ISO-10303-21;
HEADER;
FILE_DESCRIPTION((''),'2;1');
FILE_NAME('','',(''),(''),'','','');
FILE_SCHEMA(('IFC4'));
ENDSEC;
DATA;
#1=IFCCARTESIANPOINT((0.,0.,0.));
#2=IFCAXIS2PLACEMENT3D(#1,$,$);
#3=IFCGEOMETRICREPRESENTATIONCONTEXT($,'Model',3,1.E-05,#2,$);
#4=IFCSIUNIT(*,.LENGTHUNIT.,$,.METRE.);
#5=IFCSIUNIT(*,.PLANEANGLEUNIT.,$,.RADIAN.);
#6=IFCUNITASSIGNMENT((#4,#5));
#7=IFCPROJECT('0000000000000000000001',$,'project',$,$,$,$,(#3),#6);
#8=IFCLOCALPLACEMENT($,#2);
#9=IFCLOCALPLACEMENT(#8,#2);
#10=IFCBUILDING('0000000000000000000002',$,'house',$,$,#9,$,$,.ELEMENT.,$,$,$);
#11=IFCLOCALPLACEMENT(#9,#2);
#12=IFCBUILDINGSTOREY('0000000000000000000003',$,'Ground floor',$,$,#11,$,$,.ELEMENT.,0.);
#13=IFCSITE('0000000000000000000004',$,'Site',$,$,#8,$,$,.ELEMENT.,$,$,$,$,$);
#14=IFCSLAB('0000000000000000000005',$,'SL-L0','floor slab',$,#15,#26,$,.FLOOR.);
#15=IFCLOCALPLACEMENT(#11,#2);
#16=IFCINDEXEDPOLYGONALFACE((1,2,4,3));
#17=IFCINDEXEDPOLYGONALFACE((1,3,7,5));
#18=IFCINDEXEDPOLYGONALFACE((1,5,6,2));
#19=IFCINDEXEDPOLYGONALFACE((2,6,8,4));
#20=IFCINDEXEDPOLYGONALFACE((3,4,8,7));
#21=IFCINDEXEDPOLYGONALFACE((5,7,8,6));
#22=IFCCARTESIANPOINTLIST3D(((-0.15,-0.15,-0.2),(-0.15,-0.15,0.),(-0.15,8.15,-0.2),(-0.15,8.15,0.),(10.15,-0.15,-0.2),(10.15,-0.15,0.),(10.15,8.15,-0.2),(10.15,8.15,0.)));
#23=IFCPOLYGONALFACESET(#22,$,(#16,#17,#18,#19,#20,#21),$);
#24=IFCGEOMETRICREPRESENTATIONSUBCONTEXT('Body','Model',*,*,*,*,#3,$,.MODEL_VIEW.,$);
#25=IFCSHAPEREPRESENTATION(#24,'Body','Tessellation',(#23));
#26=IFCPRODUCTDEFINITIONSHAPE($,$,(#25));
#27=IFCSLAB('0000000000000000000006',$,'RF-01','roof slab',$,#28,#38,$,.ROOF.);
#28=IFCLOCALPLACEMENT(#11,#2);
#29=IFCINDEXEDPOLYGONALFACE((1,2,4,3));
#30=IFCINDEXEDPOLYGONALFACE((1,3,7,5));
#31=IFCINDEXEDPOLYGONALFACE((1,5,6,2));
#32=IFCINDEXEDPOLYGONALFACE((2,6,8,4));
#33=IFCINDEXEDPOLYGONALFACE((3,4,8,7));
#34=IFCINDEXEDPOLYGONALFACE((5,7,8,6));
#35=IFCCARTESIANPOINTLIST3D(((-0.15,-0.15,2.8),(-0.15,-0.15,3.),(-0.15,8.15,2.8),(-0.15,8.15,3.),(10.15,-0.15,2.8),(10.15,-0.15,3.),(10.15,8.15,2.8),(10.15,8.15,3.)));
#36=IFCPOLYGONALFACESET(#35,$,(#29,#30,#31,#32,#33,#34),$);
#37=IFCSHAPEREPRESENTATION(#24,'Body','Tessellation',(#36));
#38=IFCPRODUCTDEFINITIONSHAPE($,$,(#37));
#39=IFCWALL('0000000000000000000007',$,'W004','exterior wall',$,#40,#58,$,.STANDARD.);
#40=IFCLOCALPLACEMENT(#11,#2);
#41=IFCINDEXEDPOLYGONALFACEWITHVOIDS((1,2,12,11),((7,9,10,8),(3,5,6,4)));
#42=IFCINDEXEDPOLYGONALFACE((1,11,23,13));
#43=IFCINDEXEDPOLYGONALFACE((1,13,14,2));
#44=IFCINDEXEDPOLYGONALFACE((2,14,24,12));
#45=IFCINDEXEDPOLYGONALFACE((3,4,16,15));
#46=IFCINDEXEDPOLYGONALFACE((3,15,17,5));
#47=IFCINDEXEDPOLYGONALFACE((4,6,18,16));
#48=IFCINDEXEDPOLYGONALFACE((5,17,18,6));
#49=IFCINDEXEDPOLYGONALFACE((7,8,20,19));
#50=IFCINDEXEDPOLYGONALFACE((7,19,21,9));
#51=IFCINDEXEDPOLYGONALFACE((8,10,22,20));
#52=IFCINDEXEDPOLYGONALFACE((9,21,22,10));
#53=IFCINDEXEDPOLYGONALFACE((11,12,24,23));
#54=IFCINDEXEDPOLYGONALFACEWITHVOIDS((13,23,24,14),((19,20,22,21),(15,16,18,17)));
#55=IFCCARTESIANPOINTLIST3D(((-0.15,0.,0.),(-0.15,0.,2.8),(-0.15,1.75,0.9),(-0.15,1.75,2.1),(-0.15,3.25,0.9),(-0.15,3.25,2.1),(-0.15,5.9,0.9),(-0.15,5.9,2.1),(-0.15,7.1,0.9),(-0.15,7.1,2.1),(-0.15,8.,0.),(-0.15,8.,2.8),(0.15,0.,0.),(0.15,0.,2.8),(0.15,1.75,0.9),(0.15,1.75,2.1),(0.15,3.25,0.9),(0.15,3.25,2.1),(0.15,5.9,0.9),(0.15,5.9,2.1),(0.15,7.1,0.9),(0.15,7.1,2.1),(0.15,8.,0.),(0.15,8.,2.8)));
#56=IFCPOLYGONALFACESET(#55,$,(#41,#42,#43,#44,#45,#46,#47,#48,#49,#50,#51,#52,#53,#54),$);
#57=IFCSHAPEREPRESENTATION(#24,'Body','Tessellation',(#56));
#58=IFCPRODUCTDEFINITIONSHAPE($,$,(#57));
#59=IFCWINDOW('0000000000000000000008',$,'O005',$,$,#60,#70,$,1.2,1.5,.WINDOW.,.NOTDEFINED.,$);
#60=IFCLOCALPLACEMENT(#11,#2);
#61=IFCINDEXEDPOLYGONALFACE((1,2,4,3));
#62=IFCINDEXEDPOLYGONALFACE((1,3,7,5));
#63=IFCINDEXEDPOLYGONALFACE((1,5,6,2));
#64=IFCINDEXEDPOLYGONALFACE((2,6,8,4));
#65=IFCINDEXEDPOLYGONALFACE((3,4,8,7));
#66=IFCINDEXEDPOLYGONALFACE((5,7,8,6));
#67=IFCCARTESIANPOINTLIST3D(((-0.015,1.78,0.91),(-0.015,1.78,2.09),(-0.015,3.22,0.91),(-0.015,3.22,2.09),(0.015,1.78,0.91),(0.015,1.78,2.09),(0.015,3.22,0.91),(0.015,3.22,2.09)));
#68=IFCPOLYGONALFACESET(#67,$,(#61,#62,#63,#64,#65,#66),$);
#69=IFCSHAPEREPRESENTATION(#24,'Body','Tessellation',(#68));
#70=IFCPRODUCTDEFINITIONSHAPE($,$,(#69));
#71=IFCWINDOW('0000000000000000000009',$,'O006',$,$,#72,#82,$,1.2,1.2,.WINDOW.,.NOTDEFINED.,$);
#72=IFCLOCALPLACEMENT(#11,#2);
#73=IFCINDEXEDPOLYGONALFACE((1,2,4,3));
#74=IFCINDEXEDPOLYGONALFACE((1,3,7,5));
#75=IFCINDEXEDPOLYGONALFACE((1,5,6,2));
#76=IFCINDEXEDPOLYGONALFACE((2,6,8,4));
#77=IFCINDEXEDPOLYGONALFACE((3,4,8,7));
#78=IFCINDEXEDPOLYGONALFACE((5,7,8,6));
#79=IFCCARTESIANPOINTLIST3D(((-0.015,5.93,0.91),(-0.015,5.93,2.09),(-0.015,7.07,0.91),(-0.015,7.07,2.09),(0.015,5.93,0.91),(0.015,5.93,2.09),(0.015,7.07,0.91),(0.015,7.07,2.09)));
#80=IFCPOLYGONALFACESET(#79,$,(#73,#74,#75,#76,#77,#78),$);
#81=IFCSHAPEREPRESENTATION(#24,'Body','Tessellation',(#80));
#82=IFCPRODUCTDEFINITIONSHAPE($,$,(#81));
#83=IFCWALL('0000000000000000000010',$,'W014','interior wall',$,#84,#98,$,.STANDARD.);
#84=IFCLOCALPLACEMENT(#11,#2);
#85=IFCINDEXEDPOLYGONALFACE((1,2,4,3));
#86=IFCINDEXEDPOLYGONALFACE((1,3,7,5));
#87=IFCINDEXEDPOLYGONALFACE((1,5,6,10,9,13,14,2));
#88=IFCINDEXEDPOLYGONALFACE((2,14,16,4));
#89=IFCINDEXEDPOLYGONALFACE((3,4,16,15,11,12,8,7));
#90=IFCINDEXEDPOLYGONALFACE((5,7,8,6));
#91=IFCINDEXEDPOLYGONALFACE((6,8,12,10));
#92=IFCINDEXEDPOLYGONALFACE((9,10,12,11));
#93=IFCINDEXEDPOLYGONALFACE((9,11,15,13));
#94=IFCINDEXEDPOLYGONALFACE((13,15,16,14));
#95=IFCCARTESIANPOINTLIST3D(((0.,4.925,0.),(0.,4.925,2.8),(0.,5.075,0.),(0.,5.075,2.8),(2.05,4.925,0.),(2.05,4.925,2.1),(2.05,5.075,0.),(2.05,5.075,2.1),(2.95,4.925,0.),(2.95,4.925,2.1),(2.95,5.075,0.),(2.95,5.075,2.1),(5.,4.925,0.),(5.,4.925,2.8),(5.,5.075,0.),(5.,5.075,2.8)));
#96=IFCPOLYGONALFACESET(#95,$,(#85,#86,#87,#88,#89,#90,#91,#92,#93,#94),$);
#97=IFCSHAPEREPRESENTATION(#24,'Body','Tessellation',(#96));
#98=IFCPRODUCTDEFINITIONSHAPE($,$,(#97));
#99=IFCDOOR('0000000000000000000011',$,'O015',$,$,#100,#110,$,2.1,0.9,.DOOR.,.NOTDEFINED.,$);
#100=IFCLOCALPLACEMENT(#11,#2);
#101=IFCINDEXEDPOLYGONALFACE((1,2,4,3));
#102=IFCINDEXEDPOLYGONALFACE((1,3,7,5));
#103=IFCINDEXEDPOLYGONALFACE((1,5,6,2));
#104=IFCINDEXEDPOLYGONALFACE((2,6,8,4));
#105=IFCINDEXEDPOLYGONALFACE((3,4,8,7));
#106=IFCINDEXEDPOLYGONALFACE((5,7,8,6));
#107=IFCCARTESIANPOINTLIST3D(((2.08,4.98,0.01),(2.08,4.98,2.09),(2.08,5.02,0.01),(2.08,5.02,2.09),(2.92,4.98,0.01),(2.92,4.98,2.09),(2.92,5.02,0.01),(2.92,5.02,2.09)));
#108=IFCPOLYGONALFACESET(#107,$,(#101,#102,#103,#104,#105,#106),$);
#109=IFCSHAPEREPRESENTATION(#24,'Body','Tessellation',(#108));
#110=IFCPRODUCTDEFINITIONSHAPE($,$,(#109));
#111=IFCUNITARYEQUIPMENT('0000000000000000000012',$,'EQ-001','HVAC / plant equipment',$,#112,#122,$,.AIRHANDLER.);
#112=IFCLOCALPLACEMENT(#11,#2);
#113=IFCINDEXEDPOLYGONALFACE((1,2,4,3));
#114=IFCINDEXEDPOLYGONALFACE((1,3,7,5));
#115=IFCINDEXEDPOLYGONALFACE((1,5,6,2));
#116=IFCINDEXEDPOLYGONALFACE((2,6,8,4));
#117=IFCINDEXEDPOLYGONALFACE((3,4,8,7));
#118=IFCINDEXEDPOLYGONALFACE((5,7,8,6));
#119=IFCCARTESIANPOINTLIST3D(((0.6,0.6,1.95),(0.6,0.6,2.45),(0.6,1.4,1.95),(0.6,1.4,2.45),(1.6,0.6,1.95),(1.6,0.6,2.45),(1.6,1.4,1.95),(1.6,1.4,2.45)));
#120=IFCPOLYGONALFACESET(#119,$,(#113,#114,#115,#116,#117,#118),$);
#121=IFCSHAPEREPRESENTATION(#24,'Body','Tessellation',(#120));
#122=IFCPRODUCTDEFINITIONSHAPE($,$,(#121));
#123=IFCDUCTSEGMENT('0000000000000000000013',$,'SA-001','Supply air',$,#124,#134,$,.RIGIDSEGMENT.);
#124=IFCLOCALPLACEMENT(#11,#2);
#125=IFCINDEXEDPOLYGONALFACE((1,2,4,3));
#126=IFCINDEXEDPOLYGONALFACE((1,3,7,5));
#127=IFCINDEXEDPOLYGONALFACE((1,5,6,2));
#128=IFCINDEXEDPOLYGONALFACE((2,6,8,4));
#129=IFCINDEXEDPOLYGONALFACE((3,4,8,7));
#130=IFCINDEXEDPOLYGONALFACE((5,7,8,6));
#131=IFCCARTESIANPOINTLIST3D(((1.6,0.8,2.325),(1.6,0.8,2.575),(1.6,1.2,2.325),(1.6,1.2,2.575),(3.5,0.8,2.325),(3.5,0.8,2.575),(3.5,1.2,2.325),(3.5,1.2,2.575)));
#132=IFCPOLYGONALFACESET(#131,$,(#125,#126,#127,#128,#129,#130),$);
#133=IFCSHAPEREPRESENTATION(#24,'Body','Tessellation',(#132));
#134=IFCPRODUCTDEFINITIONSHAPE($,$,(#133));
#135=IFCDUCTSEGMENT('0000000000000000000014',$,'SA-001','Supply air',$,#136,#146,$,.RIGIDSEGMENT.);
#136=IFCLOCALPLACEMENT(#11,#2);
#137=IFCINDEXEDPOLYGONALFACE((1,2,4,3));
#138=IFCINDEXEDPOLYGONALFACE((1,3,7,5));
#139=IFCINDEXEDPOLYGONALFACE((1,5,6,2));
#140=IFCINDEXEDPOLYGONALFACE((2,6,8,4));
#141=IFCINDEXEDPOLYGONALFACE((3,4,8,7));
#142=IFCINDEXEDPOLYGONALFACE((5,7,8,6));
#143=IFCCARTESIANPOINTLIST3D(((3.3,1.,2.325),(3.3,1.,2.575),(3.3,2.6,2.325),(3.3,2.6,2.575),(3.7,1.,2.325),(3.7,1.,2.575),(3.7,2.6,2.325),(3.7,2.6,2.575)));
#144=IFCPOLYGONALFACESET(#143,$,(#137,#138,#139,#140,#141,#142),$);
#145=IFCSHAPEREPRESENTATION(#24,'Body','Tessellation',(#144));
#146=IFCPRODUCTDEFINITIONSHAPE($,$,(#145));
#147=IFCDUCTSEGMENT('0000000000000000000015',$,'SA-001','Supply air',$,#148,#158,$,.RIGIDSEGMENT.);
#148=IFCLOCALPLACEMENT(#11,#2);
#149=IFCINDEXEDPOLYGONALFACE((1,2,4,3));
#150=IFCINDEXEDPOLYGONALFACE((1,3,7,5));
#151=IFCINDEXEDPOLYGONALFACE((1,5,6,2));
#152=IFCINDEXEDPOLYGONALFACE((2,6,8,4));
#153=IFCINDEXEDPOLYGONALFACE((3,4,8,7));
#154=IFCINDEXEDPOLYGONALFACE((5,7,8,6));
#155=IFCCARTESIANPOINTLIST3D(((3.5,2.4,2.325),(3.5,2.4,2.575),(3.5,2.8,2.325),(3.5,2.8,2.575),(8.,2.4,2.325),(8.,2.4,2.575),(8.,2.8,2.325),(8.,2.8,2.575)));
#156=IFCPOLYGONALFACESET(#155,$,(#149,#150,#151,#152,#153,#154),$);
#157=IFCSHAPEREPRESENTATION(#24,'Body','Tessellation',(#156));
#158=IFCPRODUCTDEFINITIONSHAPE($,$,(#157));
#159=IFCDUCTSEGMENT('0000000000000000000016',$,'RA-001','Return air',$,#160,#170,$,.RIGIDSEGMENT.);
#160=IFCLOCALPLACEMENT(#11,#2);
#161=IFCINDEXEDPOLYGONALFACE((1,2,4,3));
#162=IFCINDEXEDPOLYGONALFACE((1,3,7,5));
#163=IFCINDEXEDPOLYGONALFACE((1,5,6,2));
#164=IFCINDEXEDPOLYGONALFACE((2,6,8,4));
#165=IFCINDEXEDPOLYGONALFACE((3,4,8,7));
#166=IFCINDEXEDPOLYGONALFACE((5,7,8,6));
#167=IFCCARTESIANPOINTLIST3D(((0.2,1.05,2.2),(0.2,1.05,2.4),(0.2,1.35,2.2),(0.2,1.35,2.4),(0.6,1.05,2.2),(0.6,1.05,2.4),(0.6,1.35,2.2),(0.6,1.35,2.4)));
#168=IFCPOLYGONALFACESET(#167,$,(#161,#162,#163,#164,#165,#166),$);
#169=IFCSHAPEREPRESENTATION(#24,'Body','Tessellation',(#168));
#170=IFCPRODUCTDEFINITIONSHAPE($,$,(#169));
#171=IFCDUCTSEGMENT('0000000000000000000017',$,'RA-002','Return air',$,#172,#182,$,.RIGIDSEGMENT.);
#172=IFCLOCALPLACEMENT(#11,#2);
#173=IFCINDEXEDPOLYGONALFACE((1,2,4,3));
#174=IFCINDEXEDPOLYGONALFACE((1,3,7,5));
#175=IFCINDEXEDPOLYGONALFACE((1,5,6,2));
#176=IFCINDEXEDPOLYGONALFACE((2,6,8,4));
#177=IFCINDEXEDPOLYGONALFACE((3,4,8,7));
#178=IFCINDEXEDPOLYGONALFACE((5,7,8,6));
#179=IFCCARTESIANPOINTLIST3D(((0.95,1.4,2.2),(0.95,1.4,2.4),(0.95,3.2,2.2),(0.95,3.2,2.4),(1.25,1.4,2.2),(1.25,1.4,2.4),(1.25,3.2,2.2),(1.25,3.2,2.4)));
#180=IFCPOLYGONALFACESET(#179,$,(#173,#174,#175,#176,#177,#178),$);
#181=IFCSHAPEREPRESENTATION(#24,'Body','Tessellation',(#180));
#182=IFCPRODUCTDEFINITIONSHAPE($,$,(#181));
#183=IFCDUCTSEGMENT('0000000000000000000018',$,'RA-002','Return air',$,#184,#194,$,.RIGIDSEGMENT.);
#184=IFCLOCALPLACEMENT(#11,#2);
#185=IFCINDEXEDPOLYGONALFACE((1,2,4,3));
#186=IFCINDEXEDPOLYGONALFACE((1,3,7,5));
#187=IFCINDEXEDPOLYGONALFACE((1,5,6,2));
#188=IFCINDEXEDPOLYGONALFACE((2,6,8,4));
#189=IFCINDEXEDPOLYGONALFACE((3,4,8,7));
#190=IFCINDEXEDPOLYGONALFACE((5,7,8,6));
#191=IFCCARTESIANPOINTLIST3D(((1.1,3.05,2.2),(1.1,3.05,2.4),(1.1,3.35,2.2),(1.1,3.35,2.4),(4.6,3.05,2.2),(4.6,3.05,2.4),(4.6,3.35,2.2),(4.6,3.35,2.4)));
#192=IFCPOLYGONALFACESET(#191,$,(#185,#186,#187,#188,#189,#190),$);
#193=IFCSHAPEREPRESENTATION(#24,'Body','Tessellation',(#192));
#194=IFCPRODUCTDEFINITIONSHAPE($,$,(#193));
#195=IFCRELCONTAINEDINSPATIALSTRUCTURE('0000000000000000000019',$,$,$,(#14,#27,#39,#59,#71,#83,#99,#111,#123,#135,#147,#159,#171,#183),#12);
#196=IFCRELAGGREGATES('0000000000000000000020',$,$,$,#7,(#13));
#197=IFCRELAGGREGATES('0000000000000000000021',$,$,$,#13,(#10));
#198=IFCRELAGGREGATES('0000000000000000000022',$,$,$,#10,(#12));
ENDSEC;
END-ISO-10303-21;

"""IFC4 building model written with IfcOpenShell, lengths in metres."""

from ifc_helpers import new_model, si_unit, frame, origin, origin_2d, place, context, subcontext, project, spatial, polyline, rectangle, outline, extrude, element, fill, save


model = new_model("IFC4")

# Units and contexts
model_context = context("Model", 3, precision=1e-05, world=origin())
body_context = subcontext(model_context, "Body", "Model", "MODEL_VIEW")
ifc_project = project(units=[si_unit("LENGTHUNIT", "METRE"), si_unit("PLANEANGLEUNIT", "RADIAN")], contexts=[model_context])

# Site, building, storey
site_placement = place(None, origin())
site = spatial("IfcSite", under=ifc_project, at=site_placement, Name="Site", CompositionType="ELEMENT")
building_placement = place(site_placement, origin())
building = spatial("IfcBuilding", under=site, at=building_placement, Name="house", CompositionType="ELEMENT")
storey_placement = place(building_placement, origin())
storey = spatial("IfcBuildingStorey", under=building, at=storey_placement, Name="Ground floor", CompositionType="ELEMENT", Elevation=0.0)

# Slabs
slab_1_placement = place(storey_placement, frame((0.0, 0.0, -0.2)))
element("IfcSlab", 1, at=slab_1_placement, inside=storey, Name="SL-L0", Description="floor slab", PredefinedType="FLOOR", context=body_context, shape_type="SweptSolid", body=[
    extrude(outline(polyline([(-0.15, 8.15), (10.15, 8.15), (10.15, -0.15), (-0.15, -0.15), (-0.15, 8.15)])), origin(), (0.0, 0.0, 1.0), 0.2),
])
slab_2_placement = place(storey_placement, frame((0.0, 0.0, 2.8)))
element("IfcSlab", 2, at=slab_2_placement, inside=storey, Name="RF-01", Description="roof slab", PredefinedType="ROOF", context=body_context, shape_type="SweptSolid", body=[
    extrude(outline(polyline([(-0.15, 8.15), (10.15, 8.15), (10.15, -0.15), (-0.15, -0.15), (-0.15, 8.15)])), origin(), (0.0, 0.0, 1.0), 0.2),
])

# Wall, openings, windows
wall_1_placement = place(storey_placement, frame((0.0, 4.0, 0.0), z_axis=(0.0, 0.0, 1.0), x_axis=(0.0, 1.0, 0.0)))
wall_1 = element("IfcWall", 3, at=wall_1_placement, inside=storey, Name="W004", Description="exterior wall", PredefinedType="STANDARD", context=body_context, shape_type="SweptSolid", body=[
    extrude(rectangle(XDim=8.0, YDim=0.3, at=origin_2d()), origin(), (0.0, 0.0, 1.0), 2.8),
])
opening_1_placement = place(wall_1_placement, frame((-1.5, 0.0, 0.9)))
opening_1 = element("IfcOpeningElement", 4, at=opening_1_placement, cuts=wall_1, PredefinedType="OPENING", context=body_context, shape_type="SweptSolid", body=[
    extrude(rectangle(XDim=1.5, YDim=0.36, at=origin_2d()), origin(), (0.0, 0.0, 1.0), 1.2),
])
opening_2_placement = place(wall_1_placement, frame((2.5, 0.0, 0.9)))
opening_2 = element("IfcOpeningElement", 5, at=opening_2_placement, cuts=wall_1, PredefinedType="OPENING", context=body_context, shape_type="SweptSolid", body=[
    extrude(rectangle(XDim=1.2, YDim=0.36, at=origin_2d()), origin(), (0.0, 0.0, 1.0), 1.2),
])
window_1_placement = place(wall_1_placement, frame((-1.5, 0.0, 0.9)))
window_1 = element("IfcWindow", 6, at=window_1_placement, inside=storey, Name="O005", OverallHeight=1.2, OverallWidth=1.5, PartitioningType="NOTDEFINED", PredefinedType="WINDOW", context=body_context, shape_type="SweptSolid", body=[
    extrude(rectangle(XDim=1.44, YDim=0.03, at=origin_2d()), frame((0.0, 0.0, 0.01)), (0.0, 0.0, 1.0), 1.18),
])
fill(opening_1, window_1)
window_2_placement = place(wall_1_placement, frame((2.5, 0.0, 0.9)))
window_2 = element("IfcWindow", 7, at=window_2_placement, inside=storey, Name="O006", OverallHeight=1.2, OverallWidth=1.2, PartitioningType="NOTDEFINED", PredefinedType="WINDOW", context=body_context, shape_type="SweptSolid", body=[
    extrude(rectangle(XDim=1.14, YDim=0.03, at=origin_2d()), frame((0.0, 0.0, 0.01)), (0.0, 0.0, 1.0), 1.18),
])
fill(opening_2, window_2)

# Wall, opening, door
wall_2_placement = place(storey_placement, frame((2.5, 5.0, 0.0), z_axis=(0.0, 0.0, 1.0), x_axis=(1.0, 0.0, 0.0)))
wall_2 = element("IfcWall", 8, at=wall_2_placement, inside=storey, Name="W014", Description="interior wall", PredefinedType="STANDARD", context=body_context, shape_type="SweptSolid", body=[
    extrude(rectangle(XDim=5.0, YDim=0.15, at=origin_2d()), origin(), (0.0, 0.0, 1.0), 2.8),
])
opening_3_placement = place(wall_2_placement, origin())
opening_3 = element("IfcOpeningElement", 9, at=opening_3_placement, cuts=wall_2, PredefinedType="OPENING", context=body_context, shape_type="SweptSolid", body=[
    extrude(rectangle(XDim=0.9, YDim=0.18, at=origin_2d()), origin(), (0.0, 0.0, 1.0), 2.1),
])
door_placement = place(wall_2_placement, origin())
door = element("IfcDoor", 10, at=door_placement, inside=storey, Name="O015", OperationType="NOTDEFINED", OverallHeight=2.1, OverallWidth=0.9, PredefinedType="DOOR", context=body_context, shape_type="SweptSolid", body=[
    extrude(rectangle(XDim=0.84, YDim=0.04, at=origin_2d()), frame((0.0, 0.0, 0.01)), (0.0, 0.0, 1.0), 2.08),
])
fill(opening_3, door)

# Unitary equipment
unitary_equipment_placement = place(storey_placement, frame((1.1, 1.0, 1.95), z_axis=(0.0, 0.0, 1.0), x_axis=(1.0, 0.0, 0.0)))
element("IfcUnitaryEquipment", 11, at=unitary_equipment_placement, inside=storey, Name="EQ-001", Description="HVAC / plant equipment", PredefinedType="AIRHANDLER", context=body_context, shape_type="SweptSolid", body=[
    extrude(rectangle(XDim=1.0, YDim=0.8, at=origin_2d()), origin(), (0.0, 0.0, 1.0), 0.5),
])

# Duct segments
duct_segment_1_placement = place(storey_placement, frame((1.6, 1.0, 2.45), z_axis=(1.0, 0.0, 0.0), x_axis=(0.0, 1.0, 0.0)))
element("IfcDuctSegment", 12, at=duct_segment_1_placement, inside=storey, Name="SA-001", Description="Supply air", PredefinedType="RIGIDSEGMENT", context=body_context, shape_type="SweptSolid", body=[
    extrude(rectangle(XDim=0.4, YDim=0.25, at=origin_2d()), origin(), (0.0, 0.0, 1.0), 1.9),
])
duct_segment_2_placement = place(storey_placement, frame((3.5, 1.0, 2.45), z_axis=(0.0, 1.0, 0.0), x_axis=(-1.0, 0.0, 0.0)))
element("IfcDuctSegment", 13, at=duct_segment_2_placement, inside=storey, Name="SA-001", Description="Supply air", PredefinedType="RIGIDSEGMENT", context=body_context, shape_type="SweptSolid", body=[
    extrude(rectangle(XDim=0.4, YDim=0.25, at=origin_2d()), origin(), (0.0, 0.0, 1.0), 1.6),
])
duct_segment_3_placement = place(storey_placement, frame((3.5, 2.6, 2.45), z_axis=(1.0, 0.0, 0.0), x_axis=(0.0, 1.0, 0.0)))
element("IfcDuctSegment", 14, at=duct_segment_3_placement, inside=storey, Name="SA-001", Description="Supply air", PredefinedType="RIGIDSEGMENT", context=body_context, shape_type="SweptSolid", body=[
    extrude(rectangle(XDim=0.4, YDim=0.25, at=origin_2d()), origin(), (0.0, 0.0, 1.0), 4.5),
])
duct_segment_4_placement = place(storey_placement, frame((0.6, 1.2, 2.3), z_axis=(-1.0, 0.0, 0.0), x_axis=(0.0, -1.0, 0.0)))
element("IfcDuctSegment", 15, at=duct_segment_4_placement, inside=storey, Name="RA-001", Description="Return air", PredefinedType="RIGIDSEGMENT", context=body_context, shape_type="SweptSolid", body=[
    extrude(rectangle(XDim=0.3, YDim=0.2, at=origin_2d()), origin(), (0.0, 0.0, 1.0), 0.4),
])
duct_segment_5_placement = place(storey_placement, frame((1.1, 1.4, 2.3), z_axis=(0.0, 1.0, 0.0), x_axis=(-1.0, 0.0, 0.0)))
element("IfcDuctSegment", 16, at=duct_segment_5_placement, inside=storey, Name="RA-002", Description="Return air", PredefinedType="RIGIDSEGMENT", context=body_context, shape_type="SweptSolid", body=[
    extrude(rectangle(XDim=0.3, YDim=0.2, at=origin_2d()), origin(), (0.0, 0.0, 1.0), 1.8),
])
duct_segment_6_placement = place(storey_placement, frame((1.1, 3.2, 2.3), z_axis=(1.0, 0.0, 0.0), x_axis=(0.0, 1.0, 0.0)))
element("IfcDuctSegment", 17, at=duct_segment_6_placement, inside=storey, Name="RA-002", Description="Return air", PredefinedType="RIGIDSEGMENT", context=body_context, shape_type="SweptSolid", body=[
    extrude(rectangle(XDim=0.3, YDim=0.2, at=origin_2d()), origin(), (0.0, 0.0, 1.0), 3.5),
])

save(model, "model.ifc")
